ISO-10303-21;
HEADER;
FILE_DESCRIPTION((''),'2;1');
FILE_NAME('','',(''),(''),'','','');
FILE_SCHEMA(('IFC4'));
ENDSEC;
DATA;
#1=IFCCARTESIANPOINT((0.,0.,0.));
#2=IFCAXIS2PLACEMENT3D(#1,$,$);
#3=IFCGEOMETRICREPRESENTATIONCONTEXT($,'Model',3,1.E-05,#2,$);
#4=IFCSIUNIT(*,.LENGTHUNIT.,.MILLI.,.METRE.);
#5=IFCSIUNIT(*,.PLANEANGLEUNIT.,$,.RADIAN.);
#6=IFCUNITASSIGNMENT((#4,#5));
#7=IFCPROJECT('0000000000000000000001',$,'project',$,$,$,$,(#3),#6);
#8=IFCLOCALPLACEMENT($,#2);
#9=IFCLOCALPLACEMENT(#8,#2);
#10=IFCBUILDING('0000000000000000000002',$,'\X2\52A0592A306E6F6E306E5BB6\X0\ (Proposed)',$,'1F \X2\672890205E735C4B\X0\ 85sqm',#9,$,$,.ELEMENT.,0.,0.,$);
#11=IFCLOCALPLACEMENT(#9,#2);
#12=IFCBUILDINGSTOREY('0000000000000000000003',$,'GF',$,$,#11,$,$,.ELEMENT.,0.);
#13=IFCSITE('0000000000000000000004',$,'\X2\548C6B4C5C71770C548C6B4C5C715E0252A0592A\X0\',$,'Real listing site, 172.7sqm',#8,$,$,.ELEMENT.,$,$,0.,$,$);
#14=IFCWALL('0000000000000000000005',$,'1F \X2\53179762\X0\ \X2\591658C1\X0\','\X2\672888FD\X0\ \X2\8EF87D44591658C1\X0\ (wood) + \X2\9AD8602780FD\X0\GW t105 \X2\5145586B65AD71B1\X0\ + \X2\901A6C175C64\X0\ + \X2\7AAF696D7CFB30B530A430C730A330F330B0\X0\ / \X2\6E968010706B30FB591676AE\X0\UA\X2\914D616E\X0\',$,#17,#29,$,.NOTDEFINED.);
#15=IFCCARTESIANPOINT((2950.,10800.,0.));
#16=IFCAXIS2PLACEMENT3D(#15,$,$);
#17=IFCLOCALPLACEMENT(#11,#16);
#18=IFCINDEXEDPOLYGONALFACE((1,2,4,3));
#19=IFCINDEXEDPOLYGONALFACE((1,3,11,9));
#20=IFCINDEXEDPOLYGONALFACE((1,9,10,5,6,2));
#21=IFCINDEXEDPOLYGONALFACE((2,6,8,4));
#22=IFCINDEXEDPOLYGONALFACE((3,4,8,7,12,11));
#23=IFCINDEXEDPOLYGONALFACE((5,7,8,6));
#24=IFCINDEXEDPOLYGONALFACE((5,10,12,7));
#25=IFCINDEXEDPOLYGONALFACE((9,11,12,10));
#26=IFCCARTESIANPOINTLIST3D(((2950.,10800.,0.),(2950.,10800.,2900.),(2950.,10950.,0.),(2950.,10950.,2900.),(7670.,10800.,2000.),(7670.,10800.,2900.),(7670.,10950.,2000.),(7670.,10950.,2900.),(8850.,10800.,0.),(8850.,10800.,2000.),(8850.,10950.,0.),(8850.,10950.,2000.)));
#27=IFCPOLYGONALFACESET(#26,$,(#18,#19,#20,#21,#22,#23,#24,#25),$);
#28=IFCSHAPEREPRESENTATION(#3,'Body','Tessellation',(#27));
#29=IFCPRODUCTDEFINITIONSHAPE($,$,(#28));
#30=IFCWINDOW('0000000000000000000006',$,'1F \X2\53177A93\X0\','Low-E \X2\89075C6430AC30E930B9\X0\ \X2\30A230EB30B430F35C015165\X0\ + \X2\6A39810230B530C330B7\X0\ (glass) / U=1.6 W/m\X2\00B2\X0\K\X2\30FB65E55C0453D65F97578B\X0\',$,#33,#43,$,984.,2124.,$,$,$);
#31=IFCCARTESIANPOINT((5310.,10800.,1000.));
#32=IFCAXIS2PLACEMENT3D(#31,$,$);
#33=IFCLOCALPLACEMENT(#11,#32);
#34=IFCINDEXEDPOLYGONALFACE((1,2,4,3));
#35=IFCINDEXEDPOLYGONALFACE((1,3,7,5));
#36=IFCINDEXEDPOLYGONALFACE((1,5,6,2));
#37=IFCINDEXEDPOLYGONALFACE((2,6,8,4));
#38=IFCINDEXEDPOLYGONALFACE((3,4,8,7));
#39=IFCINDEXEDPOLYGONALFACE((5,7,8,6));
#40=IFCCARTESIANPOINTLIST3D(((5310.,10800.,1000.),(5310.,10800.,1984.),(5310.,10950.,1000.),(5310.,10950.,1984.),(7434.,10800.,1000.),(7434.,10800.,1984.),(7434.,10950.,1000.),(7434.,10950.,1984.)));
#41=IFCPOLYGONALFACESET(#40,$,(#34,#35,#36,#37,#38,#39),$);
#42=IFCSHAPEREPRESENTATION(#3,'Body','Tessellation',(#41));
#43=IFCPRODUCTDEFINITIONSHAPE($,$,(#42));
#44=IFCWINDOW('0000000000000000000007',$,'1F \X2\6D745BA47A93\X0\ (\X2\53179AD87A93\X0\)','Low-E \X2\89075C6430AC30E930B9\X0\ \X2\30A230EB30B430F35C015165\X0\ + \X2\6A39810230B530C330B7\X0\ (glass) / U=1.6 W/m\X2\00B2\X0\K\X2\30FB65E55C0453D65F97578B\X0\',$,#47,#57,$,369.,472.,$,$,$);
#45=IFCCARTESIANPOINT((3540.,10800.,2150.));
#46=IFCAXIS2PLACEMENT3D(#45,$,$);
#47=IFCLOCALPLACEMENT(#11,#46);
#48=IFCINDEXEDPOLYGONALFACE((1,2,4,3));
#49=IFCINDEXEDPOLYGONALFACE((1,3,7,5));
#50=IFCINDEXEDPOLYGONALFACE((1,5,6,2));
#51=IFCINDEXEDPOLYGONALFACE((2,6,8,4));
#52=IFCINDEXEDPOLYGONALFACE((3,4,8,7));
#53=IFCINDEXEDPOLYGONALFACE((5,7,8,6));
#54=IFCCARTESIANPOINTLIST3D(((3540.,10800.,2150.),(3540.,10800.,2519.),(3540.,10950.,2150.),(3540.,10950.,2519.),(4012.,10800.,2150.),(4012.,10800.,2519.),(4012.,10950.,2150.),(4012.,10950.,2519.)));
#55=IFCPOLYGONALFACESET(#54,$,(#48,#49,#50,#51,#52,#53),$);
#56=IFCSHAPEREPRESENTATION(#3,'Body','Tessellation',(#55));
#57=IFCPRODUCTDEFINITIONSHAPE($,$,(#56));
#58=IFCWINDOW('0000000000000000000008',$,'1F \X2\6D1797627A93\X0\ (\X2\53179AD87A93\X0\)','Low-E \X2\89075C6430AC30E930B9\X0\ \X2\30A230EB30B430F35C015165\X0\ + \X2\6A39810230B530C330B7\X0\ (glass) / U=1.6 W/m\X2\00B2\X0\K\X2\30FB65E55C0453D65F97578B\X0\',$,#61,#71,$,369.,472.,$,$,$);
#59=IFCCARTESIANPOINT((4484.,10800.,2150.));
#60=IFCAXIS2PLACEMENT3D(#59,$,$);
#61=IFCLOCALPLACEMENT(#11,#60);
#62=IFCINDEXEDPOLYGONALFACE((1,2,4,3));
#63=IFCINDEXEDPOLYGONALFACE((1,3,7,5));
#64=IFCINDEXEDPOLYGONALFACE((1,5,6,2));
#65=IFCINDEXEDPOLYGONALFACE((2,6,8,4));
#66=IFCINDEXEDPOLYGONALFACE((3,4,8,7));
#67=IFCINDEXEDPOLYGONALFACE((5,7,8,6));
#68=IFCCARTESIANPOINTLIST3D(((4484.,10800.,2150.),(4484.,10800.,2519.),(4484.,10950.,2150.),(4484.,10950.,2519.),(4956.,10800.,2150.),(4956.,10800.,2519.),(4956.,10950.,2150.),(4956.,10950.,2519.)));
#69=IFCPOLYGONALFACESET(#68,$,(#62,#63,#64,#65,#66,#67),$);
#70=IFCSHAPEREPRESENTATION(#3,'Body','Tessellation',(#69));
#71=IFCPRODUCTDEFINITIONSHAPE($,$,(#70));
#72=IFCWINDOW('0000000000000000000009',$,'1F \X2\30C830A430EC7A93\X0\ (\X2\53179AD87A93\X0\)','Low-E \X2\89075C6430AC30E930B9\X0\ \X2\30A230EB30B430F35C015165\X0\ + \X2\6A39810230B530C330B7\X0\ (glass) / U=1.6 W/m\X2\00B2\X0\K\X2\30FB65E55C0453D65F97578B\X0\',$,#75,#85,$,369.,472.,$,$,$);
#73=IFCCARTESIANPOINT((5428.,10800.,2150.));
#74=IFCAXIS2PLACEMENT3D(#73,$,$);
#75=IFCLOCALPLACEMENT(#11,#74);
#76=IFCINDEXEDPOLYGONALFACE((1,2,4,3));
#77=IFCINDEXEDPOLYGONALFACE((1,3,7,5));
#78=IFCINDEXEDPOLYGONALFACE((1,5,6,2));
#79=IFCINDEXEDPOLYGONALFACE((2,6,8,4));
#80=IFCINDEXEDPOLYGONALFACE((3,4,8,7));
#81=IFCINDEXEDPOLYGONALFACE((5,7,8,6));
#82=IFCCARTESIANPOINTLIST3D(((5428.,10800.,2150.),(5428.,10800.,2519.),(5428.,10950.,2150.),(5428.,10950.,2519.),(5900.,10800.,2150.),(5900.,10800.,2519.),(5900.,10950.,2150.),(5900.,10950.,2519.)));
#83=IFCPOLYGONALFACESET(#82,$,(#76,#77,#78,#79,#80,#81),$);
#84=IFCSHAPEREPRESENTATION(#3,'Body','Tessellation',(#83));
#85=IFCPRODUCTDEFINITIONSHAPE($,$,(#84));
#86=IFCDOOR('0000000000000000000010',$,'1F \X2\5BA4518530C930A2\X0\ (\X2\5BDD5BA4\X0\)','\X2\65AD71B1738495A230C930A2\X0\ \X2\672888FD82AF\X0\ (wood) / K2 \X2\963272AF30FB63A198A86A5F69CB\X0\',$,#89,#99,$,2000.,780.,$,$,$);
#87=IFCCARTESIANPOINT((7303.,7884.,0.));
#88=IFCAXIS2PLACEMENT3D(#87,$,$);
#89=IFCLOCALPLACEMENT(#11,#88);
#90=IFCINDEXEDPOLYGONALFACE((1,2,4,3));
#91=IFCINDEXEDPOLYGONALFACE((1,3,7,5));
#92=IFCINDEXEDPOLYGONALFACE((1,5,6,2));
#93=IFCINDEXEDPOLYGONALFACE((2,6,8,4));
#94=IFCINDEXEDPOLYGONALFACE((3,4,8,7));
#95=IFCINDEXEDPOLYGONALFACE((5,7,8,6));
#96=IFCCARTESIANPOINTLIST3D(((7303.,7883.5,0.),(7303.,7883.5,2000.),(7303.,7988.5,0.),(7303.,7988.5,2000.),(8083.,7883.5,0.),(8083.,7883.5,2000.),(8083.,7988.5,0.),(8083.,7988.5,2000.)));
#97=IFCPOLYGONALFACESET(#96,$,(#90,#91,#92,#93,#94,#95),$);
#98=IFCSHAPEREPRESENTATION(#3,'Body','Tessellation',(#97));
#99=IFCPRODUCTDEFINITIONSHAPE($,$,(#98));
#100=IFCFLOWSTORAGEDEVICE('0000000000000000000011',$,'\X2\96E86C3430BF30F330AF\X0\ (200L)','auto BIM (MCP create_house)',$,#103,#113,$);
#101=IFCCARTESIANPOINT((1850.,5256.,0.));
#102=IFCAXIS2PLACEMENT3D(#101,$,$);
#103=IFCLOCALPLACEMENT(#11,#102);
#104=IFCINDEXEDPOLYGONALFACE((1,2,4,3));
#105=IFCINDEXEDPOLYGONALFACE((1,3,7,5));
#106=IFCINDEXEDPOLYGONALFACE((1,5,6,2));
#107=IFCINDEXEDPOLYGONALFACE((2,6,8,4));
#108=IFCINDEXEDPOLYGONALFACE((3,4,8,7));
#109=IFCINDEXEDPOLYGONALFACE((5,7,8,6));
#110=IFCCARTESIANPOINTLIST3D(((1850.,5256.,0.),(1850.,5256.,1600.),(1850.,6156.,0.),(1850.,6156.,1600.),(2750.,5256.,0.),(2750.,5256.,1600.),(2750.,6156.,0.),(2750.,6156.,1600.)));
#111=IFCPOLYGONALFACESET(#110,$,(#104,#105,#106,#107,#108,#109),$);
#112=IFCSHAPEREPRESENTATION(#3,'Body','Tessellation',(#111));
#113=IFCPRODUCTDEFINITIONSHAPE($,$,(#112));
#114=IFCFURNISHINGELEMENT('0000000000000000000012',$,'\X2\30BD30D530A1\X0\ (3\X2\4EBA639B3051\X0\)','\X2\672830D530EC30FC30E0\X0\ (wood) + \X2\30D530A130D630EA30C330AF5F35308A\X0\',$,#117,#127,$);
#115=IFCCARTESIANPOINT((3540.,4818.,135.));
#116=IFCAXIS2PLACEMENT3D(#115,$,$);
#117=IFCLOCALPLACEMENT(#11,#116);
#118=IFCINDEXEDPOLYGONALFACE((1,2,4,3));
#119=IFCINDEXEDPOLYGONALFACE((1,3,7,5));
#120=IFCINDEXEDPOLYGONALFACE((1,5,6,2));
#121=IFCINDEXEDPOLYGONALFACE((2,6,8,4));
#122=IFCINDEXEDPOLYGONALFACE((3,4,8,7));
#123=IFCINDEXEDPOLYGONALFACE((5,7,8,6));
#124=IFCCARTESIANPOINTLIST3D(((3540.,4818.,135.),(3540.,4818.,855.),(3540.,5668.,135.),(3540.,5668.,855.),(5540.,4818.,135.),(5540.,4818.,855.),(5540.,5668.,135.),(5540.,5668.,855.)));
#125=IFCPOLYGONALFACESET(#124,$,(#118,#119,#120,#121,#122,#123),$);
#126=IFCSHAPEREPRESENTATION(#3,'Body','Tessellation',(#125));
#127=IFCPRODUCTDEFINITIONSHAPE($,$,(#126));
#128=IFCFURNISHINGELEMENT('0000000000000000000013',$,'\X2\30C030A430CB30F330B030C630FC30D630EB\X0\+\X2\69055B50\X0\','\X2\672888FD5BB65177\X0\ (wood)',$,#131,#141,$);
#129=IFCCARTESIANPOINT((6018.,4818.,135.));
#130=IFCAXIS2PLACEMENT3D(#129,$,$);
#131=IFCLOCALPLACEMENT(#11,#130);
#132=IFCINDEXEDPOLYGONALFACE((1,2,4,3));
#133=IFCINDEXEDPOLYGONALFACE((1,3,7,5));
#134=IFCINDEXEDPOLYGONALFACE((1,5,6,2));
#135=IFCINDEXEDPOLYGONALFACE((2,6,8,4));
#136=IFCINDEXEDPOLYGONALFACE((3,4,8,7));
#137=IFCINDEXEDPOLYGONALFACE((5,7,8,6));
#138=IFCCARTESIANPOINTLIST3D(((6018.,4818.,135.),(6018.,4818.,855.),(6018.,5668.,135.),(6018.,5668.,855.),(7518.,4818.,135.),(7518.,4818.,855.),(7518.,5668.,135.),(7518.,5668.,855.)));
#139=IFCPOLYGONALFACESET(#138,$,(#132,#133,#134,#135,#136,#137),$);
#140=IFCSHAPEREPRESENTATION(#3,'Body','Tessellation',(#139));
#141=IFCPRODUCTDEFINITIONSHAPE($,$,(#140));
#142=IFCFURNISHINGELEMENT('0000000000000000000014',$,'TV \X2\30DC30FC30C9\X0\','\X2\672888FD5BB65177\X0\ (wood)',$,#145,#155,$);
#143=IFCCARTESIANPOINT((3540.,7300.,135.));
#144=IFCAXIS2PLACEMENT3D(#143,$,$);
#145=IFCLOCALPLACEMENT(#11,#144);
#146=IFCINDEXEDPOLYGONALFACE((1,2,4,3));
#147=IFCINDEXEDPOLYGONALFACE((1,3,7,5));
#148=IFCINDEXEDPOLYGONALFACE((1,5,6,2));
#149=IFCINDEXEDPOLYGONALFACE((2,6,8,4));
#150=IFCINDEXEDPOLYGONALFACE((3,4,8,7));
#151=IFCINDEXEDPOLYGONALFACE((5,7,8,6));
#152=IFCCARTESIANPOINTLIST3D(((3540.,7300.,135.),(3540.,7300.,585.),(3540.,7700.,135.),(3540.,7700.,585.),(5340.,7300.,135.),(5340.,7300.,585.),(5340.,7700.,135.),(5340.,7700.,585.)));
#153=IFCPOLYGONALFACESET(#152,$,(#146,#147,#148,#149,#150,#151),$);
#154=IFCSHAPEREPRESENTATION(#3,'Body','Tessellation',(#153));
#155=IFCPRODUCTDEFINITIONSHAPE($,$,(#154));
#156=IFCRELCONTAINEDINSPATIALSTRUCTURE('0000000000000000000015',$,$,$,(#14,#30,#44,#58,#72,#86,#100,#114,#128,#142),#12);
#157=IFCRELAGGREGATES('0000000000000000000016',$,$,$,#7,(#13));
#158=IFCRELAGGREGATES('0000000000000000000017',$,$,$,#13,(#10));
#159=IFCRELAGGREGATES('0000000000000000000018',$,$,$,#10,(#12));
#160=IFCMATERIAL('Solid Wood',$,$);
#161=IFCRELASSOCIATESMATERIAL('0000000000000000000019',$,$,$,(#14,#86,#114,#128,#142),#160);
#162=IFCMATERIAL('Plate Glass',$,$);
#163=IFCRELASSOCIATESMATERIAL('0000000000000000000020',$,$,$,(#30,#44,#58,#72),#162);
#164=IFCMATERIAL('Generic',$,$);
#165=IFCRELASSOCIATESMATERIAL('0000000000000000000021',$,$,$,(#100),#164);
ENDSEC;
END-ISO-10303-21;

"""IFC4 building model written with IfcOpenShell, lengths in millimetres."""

from ifc_helpers import new_model, si_unit, frame, frame_2d, origin, place, context, project, spatial, rectangle, extrude, material, element, fill, save


model = new_model("IFC4")

# Units and contexts
model_context = context("Model", 3, precision=1e-05, world=origin())
ifc_project = project(units=[si_unit("LENGTHUNIT", "METRE", prefix="MILLI"), si_unit("PLANEANGLEUNIT", "RADIAN")], contexts=[model_context])

# Site, building, storey
site_placement = place(None, origin())
site = spatial("IfcSite", under=ifc_project, at=site_placement, Name="和歌山県和歌山市加太", ObjectType="Real listing site, 172.7sqm", CompositionType="ELEMENT", RefElevation=0.0)
building_placement = place(site_placement, origin())
building = spatial("IfcBuilding", under=site, at=building_placement, Name="加太の潮の家 (Proposed)", ObjectType="1F 木造平屋 85sqm", CompositionType="ELEMENT", ElevationOfRefHeight=0.0, ElevationOfTerrain=0.0)
storey_placement = place(building_placement, origin())
storey = spatial("IfcBuildingStorey", under=building, at=storey_placement, Name="GF", CompositionType="ELEMENT", Elevation=0.0)

# Wall, openings, windows
ifc_material_1 = material(Name="Solid Wood")
wall_1_placement = place(storey_placement, frame((2950.0, 10800.0, 0.0)))
wall_1 = element("IfcWall", 1, at=wall_1_placement, inside=storey, material=ifc_material_1, Name="1F 北面 外壁", Description="木製 軸組外壁 (wood) + 高性能GW t105 充填断熱 + 通気層 + 窯業系サイディング / 準耐火・外皮UA配慮", PredefinedType="NOTDEFINED", context=model_context, shape_type="SweptSolid", body=[
    extrude(rectangle(XDim=5900.0, YDim=150.0, at=frame_2d((2950.0, 75.0))), frame((2950.0, 10800.0, 0.0)), (0.0, 0.0, 1.0), 2900.0),
])
opening_1_placement = place(storey_placement, frame((5310.0, 10800.0, 1000.0)))
opening_1 = element("IfcOpeningElement", 2, at=opening_1_placement, cuts=wall_1, PredefinedType="NOTDEFINED", context=model_context, shape_type="SweptSolid", body=[
    extrude(rectangle(XDim=2124.0, YDim=150.0, at=frame_2d((1062.0, 75.0))), frame((5310.0, 10800.0, 1000.0)), (0.0, 0.0, 1.0), 984.0),
])
opening_2_placement = place(storey_placement, frame((3540.0, 10800.0, 2150.0)))
opening_2 = element("IfcOpeningElement", 3, at=opening_2_placement, cuts=wall_1, PredefinedType="NOTDEFINED", context=model_context, shape_type="SweptSolid", body=[
    extrude(rectangle(XDim=472.0, YDim=150.0, at=frame_2d((236.0, 75.0))), frame((3540.0, 10800.0, 2150.0)), (0.0, 0.0, 1.0), 369.0),
])
opening_3_placement = place(storey_placement, frame((4484.0, 10800.0, 2150.0)))
opening_3 = element("IfcOpeningElement", 4, at=opening_3_placement, cuts=wall_1, PredefinedType="NOTDEFINED", context=model_context, shape_type="SweptSolid", body=[
    extrude(rectangle(XDim=472.0, YDim=150.0, at=frame_2d((236.0, 75.0))), frame((4484.0, 10800.0, 2150.0)), (0.0, 0.0, 1.0), 369.0),
])
opening_4_placement = place(storey_placement, frame((5428.0, 10800.0, 2150.0)))
opening_4 = element("IfcOpeningElement", 5, at=opening_4_placement, cuts=wall_1, PredefinedType="NOTDEFINED", context=model_context, shape_type="SweptSolid", body=[
    extrude(rectangle(XDim=472.0, YDim=150.0, at=frame_2d((236.0, 75.0))), frame((5428.0, 10800.0, 2150.0)), (0.0, 0.0, 1.0), 369.0),
])
ifc_material_2 = material(Name="Plate Glass")
window_1_placement = place(storey_placement, frame((5310.0, 10800.0, 1000.0)))
window_1 = element("IfcWindow", 6, at=window_1_placement, inside=storey, material=ifc_material_2, Name="1F 北窓", Description="Low-E 複層ガラス アルゴン封入 + 樹脂サッシ (glass) / U=1.6 W/m²K・日射取得型", OverallHeight=984.0, OverallWidth=2124.0, context=model_context, shape_type="SweptSolid", body=[
    extrude(rectangle(XDim=2124.0, YDim=150.0, at=frame_2d((1062.0, 75.0))), frame((5310.0, 10800.0, 1000.0)), (0.0, 0.0, 1.0), 984.0),
])
fill(opening_1, window_1)
window_2_placement = place(storey_placement, frame((3540.0, 10800.0, 2150.0)))
window_2 = element("IfcWindow", 7, at=window_2_placement, inside=storey, material=ifc_material_2, Name="1F 浴室窓 (北高窓)", Description="Low-E 複層ガラス アルゴン封入 + 樹脂サッシ (glass) / U=1.6 W/m²K・日射取得型", OverallHeight=369.0, OverallWidth=472.0, context=model_context, shape_type="SweptSolid", body=[
    extrude(rectangle(XDim=472.0, YDim=150.0, at=frame_2d((236.0, 75.0))), frame((3540.0, 10800.0, 2150.0)), (0.0, 0.0, 1.0), 369.0),
])
fill(opening_2, window_2)
window_3_placement = place(storey_placement, frame((4484.0, 10800.0, 2150.0)))
window_3 = element("IfcWindow", 8, at=window_3_placement, inside=storey, material=ifc_material_2, Name="1F 洗面窓 (北高窓)", Description="Low-E 複層ガラス アルゴン封入 + 樹脂サッシ (glass) / U=1.6 W/m²K・日射取得型", OverallHeight=369.0, OverallWidth=472.0, context=model_context, shape_type="SweptSolid", body=[
    extrude(rectangle(XDim=472.0, YDim=150.0, at=frame_2d((236.0, 75.0))), frame((4484.0, 10800.0, 2150.0)), (0.0, 0.0, 1.0), 369.0),
])
fill(opening_3, window_3)
window_4_placement = place(storey_placement, frame((5428.0, 10800.0, 2150.0)))
window_4 = element("IfcWindow", 9, at=window_4_placement, inside=storey, material=ifc_material_2, Name="1F トイレ窓 (北高窓)", Description="Low-E 複層ガラス アルゴン封入 + 樹脂サッシ (glass) / U=1.6 W/m²K・日射取得型", OverallHeight=369.0, OverallWidth=472.0, context=model_context, shape_type="SweptSolid", body=[
    extrude(rectangle(XDim=472.0, YDim=150.0, at=frame_2d((236.0, 75.0))), frame((5428.0, 10800.0, 2150.0)), (0.0, 0.0, 1.0), 369.0),
])
fill(opening_4, window_4)

# Door
door_1_placement = place(storey_placement, frame((7303.0, 7884.0, 0.0)))
element("IfcDoor", 10, at=door_1_placement, inside=storey, material=ifc_material_1, Name="1F 室内ドア (寝室)", Description="断熱玄関ドア 木製芯 (wood) / K2 防犯・採風機構", OverallHeight=2000.0, OverallWidth=780.0, context=model_context, shape_type="SweptSolid", body=[
    extrude(rectangle(XDim=780.0, YDim=105.0, at=frame_2d((390.0, 52.0))), frame((7303.0, 7884.0, 0.0)), (0.0, 0.0, 1.0), 2000.0),
])

# Flow storage device
ifc_material_3 = material(Name="Generic")
flow_storage_device_placement = place(storey_placement, frame((1850.0, 5256.0, 0.0)))
element("IfcFlowStorageDevice", 11, at=flow_storage_device_placement, inside=storey, material=ifc_material_3, Name="雨水タンク (200L)", Description="auto BIM (MCP create_house)", context=model_context, shape_type="SweptSolid", body=[
    extrude(rectangle(XDim=900.0, YDim=900.0, at=frame_2d((450.0, 450.0))), frame((1850.0, 5256.0, 0.0)), (0.0, 0.0, 1.0), 1600.0),
])

# Furnishing elements
furnishing_1_placement = place(storey_placement, frame((3540.0, 4818.0, 135.0)))
element("IfcFurnishingElement", 12, at=furnishing_1_placement, inside=storey, material=ifc_material_1, Name="ソファ (3人掛け)", Description="木フレーム (wood) + ファブリック張り", context=model_context, shape_type="SweptSolid", body=[
    extrude(rectangle(XDim=2000.0, YDim=850.0, at=frame_2d((1000.0, 425.0))), frame((3540.0, 4818.0, 135.0)), (0.0, 0.0, 1.0), 720.0),
])
furnishing_2_placement = place(storey_placement, frame((6018.0, 4818.0, 135.0)))
element("IfcFurnishingElement", 13, at=furnishing_2_placement, inside=storey, material=ifc_material_1, Name="ダイニングテーブル+椅子", Description="木製家具 (wood)", context=model_context, shape_type="SweptSolid", body=[
    extrude(rectangle(XDim=1500.0, YDim=850.0, at=frame_2d((750.0, 425.0))), frame((6018.0, 4818.0, 135.0)), (0.0, 0.0, 1.0), 720.0),
])
furnishing_3_placement = place(storey_placement, frame((3540.0, 7300.0, 135.0)))
element("IfcFurnishingElement", 14, at=furnishing_3_placement, inside=storey, material=ifc_material_1, Name="TV ボード", Description="木製家具 (wood)", context=model_context, shape_type="SweptSolid", body=[
    extrude(rectangle(XDim=1800.0, YDim=400.0, at=frame_2d((900.0, 200.0))), frame((3540.0, 7300.0, 135.0)), (0.0, 0.0, 1.0), 450.0),
])

save(model, "model.ifc")
